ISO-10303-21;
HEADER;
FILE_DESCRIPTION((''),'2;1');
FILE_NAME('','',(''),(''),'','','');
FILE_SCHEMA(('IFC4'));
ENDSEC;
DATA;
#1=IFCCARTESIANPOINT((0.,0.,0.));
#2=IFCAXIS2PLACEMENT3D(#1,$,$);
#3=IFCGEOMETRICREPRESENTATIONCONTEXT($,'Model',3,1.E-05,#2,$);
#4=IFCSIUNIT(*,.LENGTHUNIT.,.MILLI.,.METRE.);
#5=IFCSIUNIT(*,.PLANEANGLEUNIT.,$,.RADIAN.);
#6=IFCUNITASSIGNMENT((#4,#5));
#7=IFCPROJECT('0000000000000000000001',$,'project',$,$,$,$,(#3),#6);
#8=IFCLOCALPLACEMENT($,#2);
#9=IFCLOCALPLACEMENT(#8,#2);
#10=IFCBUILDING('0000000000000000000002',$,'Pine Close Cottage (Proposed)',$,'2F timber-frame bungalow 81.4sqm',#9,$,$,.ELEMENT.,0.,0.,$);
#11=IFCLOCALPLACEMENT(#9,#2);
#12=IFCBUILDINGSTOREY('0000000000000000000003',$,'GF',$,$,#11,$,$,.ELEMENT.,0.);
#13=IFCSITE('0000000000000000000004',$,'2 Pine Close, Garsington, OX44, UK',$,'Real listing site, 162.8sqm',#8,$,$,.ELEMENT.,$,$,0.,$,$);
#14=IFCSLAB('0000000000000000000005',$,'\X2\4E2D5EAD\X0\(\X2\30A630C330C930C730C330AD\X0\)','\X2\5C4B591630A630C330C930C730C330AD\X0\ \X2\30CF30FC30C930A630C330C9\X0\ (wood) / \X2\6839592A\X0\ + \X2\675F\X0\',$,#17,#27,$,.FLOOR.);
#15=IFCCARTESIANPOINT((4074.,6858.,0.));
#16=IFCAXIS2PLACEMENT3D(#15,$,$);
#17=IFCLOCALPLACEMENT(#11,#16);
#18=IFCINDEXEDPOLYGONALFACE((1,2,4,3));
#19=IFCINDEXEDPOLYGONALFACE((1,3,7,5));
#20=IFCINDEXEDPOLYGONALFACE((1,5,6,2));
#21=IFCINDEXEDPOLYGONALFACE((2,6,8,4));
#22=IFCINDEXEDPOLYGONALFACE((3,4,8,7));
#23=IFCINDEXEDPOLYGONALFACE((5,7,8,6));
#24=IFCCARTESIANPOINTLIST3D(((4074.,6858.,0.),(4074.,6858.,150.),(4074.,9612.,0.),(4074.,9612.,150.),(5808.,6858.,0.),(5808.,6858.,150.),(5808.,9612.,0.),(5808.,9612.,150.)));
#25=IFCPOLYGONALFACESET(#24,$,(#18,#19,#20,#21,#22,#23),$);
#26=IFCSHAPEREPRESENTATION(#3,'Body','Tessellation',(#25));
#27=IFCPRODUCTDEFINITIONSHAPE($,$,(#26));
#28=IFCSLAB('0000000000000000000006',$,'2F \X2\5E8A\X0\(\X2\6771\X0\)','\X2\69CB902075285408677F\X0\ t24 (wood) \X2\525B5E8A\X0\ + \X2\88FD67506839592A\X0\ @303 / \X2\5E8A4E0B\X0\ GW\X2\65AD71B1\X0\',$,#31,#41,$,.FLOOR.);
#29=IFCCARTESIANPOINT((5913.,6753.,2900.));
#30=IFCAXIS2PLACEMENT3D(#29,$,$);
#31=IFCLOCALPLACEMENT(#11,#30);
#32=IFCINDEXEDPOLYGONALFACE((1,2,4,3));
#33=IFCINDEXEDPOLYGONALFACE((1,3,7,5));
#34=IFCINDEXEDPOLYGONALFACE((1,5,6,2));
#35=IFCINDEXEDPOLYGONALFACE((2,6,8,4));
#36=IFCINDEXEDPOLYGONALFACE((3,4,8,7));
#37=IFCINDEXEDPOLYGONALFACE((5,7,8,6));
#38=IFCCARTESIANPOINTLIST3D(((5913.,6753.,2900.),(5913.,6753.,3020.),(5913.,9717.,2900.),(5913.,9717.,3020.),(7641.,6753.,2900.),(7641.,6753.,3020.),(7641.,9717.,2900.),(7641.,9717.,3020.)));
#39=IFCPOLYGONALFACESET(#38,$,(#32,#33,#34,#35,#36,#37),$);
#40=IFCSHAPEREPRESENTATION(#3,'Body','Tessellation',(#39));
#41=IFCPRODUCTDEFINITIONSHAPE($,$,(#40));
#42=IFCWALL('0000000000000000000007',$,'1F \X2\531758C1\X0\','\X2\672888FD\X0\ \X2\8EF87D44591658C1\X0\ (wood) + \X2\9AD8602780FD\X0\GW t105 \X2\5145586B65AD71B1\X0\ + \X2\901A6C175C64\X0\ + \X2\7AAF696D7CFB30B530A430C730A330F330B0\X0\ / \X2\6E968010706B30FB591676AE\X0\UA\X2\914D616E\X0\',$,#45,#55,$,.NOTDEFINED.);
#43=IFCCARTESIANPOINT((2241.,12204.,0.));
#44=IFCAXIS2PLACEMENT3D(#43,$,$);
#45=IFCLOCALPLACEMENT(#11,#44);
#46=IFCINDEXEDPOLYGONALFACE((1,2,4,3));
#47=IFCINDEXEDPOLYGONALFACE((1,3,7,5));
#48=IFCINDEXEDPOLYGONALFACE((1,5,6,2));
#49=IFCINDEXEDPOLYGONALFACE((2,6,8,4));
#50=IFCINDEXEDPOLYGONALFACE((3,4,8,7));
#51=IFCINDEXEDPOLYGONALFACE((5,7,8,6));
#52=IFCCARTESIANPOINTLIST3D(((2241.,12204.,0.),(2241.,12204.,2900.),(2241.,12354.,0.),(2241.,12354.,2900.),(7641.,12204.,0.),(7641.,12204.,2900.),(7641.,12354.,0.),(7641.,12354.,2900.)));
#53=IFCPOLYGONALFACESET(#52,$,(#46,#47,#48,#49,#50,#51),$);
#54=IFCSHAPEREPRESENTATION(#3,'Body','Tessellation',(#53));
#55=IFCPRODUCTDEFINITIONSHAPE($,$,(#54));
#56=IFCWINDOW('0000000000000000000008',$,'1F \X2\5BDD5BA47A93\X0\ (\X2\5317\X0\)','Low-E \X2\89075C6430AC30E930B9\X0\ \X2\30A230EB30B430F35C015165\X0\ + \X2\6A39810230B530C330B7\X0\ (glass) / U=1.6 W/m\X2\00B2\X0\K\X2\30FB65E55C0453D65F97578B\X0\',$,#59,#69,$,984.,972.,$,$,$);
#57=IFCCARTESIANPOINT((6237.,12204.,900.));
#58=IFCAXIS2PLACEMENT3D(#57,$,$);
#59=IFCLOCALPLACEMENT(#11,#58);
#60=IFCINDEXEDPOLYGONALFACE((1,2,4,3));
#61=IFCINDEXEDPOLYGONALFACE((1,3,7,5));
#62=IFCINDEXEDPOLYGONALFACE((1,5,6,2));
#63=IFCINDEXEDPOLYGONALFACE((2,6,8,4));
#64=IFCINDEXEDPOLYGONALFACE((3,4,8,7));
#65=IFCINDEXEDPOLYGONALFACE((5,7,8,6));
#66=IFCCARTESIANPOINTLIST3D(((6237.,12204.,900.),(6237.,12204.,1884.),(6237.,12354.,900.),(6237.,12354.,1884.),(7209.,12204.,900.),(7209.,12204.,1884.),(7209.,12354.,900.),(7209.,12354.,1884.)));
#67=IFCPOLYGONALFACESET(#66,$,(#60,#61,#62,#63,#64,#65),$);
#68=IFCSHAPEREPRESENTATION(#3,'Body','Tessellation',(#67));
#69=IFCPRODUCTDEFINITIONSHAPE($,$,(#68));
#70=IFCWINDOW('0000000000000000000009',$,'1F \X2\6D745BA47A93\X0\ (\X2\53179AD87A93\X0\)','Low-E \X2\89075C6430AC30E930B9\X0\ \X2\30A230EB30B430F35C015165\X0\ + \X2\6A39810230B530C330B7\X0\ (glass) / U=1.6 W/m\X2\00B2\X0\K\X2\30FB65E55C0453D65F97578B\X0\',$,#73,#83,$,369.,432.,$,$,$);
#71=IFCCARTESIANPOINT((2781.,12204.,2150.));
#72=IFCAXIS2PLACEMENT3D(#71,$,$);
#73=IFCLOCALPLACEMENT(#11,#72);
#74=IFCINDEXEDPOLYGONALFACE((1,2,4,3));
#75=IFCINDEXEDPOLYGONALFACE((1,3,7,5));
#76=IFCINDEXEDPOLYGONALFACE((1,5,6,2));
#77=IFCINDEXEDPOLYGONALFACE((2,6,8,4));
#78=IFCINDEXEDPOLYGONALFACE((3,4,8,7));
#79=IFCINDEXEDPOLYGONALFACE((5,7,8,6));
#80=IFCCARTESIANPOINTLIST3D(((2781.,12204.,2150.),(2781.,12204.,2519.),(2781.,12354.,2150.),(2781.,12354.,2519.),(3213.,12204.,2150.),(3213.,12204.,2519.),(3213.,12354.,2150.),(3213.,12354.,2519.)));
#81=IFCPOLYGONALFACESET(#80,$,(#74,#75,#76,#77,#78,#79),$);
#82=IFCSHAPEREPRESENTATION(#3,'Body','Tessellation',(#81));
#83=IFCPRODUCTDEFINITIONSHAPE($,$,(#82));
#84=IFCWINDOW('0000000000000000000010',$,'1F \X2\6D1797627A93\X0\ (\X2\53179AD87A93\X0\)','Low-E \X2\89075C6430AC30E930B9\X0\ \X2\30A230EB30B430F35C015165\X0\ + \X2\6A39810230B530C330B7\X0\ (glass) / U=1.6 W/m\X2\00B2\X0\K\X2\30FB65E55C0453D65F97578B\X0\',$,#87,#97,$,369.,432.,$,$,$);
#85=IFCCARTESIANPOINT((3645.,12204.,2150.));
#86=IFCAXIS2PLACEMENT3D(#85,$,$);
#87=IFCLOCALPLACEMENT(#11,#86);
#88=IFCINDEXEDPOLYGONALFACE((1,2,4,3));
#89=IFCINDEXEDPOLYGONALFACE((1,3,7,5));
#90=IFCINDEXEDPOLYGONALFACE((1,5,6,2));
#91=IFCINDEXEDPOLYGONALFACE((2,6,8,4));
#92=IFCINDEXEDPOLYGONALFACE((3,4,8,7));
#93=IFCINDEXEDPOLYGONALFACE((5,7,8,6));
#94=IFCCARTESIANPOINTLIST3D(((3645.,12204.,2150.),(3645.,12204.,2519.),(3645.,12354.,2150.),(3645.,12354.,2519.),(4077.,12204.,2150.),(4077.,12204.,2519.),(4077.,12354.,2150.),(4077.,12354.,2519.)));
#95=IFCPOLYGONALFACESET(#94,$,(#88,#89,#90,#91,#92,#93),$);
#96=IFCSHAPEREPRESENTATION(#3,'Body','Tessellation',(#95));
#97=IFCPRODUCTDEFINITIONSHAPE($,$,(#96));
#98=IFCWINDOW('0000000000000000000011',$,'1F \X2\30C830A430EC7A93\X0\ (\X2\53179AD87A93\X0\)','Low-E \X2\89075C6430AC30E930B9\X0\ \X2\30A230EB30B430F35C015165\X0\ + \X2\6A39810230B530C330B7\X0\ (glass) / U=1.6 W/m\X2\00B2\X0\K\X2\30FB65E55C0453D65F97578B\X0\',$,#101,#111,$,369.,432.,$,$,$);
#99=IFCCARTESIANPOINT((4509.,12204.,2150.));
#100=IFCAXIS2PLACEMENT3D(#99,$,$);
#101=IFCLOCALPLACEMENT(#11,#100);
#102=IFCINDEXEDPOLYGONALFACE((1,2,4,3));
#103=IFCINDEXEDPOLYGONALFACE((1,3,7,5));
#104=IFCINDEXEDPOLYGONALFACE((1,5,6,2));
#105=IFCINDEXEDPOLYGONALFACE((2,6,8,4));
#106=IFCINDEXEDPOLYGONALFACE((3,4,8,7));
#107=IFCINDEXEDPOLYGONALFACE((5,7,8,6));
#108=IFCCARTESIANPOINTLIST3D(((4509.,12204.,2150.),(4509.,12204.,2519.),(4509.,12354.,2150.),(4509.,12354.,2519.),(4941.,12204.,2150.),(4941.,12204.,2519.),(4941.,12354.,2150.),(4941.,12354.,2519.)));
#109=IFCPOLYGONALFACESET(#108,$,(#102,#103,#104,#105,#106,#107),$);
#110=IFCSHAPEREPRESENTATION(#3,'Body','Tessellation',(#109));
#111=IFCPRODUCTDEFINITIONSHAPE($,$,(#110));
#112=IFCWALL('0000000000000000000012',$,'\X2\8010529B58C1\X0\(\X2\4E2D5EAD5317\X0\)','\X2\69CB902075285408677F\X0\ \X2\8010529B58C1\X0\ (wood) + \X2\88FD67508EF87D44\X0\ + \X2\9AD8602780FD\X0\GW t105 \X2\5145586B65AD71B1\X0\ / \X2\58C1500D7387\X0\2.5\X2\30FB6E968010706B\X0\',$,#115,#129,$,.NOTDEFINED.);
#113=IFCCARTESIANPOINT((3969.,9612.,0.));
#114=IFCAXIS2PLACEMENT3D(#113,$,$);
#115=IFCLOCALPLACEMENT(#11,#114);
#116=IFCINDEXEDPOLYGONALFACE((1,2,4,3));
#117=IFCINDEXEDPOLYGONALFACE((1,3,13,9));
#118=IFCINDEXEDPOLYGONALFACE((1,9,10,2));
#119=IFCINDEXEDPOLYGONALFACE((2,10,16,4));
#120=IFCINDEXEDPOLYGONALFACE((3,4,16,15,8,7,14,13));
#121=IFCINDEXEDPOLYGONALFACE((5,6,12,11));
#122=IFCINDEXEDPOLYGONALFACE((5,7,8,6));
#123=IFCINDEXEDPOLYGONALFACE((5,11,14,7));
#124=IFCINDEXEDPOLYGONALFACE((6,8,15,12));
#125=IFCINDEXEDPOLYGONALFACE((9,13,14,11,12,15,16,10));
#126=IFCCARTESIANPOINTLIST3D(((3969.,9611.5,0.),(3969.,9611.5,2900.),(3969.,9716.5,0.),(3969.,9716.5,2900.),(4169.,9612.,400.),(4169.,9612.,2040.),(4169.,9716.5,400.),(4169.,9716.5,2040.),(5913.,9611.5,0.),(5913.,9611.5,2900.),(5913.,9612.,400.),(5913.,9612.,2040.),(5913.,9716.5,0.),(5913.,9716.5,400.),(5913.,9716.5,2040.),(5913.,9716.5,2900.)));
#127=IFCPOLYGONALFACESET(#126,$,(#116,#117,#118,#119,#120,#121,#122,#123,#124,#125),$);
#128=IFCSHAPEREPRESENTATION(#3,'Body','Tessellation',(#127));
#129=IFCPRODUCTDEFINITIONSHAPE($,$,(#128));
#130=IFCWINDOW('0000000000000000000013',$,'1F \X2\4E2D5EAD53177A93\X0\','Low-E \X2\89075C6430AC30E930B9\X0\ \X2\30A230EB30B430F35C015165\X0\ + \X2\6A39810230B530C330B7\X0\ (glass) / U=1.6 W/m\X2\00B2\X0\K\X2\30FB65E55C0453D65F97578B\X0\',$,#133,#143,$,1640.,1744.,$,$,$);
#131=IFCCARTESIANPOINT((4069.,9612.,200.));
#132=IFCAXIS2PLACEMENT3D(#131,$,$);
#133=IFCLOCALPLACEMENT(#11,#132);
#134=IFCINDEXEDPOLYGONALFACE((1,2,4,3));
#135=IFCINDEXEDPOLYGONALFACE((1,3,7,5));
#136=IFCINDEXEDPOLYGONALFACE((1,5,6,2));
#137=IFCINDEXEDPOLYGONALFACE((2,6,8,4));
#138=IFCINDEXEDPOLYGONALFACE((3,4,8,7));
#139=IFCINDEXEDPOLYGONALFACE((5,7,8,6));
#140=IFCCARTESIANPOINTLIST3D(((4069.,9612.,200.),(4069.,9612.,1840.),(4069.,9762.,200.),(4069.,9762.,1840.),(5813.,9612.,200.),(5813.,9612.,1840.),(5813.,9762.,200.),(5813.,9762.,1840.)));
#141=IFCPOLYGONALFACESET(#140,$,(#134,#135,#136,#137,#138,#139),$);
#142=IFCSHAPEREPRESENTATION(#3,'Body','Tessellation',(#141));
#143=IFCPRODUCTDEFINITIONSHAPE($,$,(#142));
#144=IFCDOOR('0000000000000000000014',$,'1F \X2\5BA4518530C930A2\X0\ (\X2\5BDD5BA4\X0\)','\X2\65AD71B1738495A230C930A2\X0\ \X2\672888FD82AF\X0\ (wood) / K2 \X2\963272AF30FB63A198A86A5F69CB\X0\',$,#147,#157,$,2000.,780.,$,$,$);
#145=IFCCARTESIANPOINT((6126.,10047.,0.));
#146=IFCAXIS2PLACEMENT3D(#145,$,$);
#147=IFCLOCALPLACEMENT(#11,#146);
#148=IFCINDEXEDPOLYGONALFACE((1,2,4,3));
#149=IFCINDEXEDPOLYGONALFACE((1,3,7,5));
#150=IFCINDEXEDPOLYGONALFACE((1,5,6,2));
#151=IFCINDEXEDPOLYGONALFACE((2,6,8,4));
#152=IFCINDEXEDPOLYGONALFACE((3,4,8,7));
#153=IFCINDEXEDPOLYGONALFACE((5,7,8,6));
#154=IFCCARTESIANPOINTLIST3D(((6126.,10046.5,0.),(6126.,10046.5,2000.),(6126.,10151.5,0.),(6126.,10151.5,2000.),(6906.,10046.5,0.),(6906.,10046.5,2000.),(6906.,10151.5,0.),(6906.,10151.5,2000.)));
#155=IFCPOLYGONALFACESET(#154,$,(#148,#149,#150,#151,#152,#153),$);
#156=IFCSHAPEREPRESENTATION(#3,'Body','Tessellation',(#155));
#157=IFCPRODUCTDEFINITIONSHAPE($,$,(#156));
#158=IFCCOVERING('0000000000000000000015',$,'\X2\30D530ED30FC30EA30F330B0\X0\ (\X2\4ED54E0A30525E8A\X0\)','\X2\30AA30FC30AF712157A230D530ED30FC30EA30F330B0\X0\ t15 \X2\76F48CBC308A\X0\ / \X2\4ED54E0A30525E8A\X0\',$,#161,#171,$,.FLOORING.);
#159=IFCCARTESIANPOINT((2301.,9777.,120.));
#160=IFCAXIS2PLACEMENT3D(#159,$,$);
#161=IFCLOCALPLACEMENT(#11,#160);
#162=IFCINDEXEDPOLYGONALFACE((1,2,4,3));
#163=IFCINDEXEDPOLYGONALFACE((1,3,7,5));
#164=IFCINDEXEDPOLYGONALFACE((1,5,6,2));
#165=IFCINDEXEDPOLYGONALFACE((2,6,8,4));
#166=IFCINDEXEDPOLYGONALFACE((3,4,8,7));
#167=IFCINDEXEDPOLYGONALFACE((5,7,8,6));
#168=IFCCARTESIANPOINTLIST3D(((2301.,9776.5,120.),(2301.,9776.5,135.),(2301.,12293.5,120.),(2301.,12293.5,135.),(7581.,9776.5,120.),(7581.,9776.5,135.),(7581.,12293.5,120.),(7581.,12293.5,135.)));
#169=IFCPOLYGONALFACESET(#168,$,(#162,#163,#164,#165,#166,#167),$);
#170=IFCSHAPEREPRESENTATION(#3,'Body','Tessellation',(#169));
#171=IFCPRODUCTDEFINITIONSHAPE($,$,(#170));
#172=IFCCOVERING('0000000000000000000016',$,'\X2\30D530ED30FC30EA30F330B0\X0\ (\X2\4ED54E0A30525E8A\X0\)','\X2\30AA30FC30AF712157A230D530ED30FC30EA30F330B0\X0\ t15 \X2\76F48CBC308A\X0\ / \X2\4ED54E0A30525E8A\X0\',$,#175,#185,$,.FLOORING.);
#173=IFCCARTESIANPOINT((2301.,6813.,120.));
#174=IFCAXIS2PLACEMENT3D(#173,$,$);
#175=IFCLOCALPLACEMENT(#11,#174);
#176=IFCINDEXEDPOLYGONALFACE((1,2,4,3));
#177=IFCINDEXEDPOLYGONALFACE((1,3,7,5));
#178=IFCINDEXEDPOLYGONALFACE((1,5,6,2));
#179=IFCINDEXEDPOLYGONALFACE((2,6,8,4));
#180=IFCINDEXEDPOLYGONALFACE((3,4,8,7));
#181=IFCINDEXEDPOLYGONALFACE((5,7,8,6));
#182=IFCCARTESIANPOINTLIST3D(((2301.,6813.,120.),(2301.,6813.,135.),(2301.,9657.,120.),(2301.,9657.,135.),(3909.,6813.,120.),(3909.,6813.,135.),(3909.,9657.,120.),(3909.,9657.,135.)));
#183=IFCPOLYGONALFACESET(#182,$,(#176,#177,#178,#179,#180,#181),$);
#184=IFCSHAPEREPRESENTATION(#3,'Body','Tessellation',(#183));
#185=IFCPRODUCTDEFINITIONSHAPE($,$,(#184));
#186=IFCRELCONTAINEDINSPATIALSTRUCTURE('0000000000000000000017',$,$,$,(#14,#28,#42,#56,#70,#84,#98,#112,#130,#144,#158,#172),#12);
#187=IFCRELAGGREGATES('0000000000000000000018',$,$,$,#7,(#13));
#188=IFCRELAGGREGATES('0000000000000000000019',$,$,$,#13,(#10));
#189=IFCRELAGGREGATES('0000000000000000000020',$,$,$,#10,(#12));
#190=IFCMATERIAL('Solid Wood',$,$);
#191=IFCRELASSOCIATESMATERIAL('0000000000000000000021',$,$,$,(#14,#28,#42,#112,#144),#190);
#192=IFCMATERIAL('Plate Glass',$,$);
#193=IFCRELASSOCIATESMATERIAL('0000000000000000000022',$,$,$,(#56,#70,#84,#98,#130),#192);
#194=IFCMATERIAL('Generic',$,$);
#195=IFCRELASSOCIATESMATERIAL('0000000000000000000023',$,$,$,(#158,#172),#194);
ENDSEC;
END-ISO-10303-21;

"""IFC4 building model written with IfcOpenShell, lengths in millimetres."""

from ifc_helpers import new_model, si_unit, frame, frame_2d, origin, place, context, project, spatial, rectangle, extrude, material, element, fill, save


model = new_model("IFC4")

# Units and contexts
model_context = context("Model", 3, precision=1e-05, world=origin())
ifc_project = project(units=[si_unit("LENGTHUNIT", "METRE", prefix="MILLI"), si_unit("PLANEANGLEUNIT", "RADIAN")], contexts=[model_context])

# Site, building, storey
site_placement = place(None, origin())
site = spatial("IfcSite", under=ifc_project, at=site_placement, Name="2 Pine Close, Garsington, OX44, UK", ObjectType="Real listing site, 162.8sqm", CompositionType="ELEMENT", RefElevation=0.0)
building_placement = place(site_placement, origin())
building = spatial("IfcBuilding", under=site, at=building_placement, Name="Pine Close Cottage (Proposed)", ObjectType="2F timber-frame bungalow 81.4sqm", CompositionType="ELEMENT", ElevationOfRefHeight=0.0, ElevationOfTerrain=0.0)
storey_placement = place(building_placement, origin())
storey = spatial("IfcBuildingStorey", under=building, at=storey_placement, Name="GF", CompositionType="ELEMENT", Elevation=0.0)

# Slabs
ifc_material_1 = material(Name="Solid Wood")
slab_1_placement = place(storey_placement, frame((4074.0, 6858.0, 0.0)))
element("IfcSlab", 1, at=slab_1_placement, inside=storey, material=ifc_material_1, Name="中庭(ウッドデッキ)", Description="屋外ウッドデッキ ハードウッド (wood) / 根太 + 束", PredefinedType="FLOOR", context=model_context, shape_type="SweptSolid", body=[
    extrude(rectangle(XDim=1734.0, YDim=2754.0, at=frame_2d((867.0, 1377.0))), frame((4074.0, 6858.0, 0.0)), (0.0, 0.0, 1.0), 150.0),
])
slab_2_placement = place(storey_placement, frame((5913.0, 6753.0, 2900.0)))
element("IfcSlab", 2, at=slab_2_placement, inside=storey, material=ifc_material_1, Name="2F 床(東)", Description="構造用合板 t24 (wood) 剛床 + 製材根太 @303 / 床下 GW断熱", PredefinedType="FLOOR", context=model_context, shape_type="SweptSolid", body=[
    extrude(rectangle(XDim=1728.0, YDim=2964.0, at=frame_2d((864.0, 1482.0))), frame((5913.0, 6753.0, 2900.0)), (0.0, 0.0, 1.0), 120.0),
])

# Wall, openings, windows
wall_1_placement = place(storey_placement, frame((2241.0, 12204.0, 0.0)))
wall_1 = element("IfcWall", 3, at=wall_1_placement, inside=storey, material=ifc_material_1, Name="1F 北壁", Description="木製 軸組外壁 (wood) + 高性能GW t105 充填断熱 + 通気層 + 窯業系サイディング / 準耐火・外皮UA配慮", PredefinedType="NOTDEFINED", context=model_context, shape_type="SweptSolid", body=[
    extrude(rectangle(XDim=5400.0, YDim=150.0, at=frame_2d((2700.0, 75.0))), frame((2241.0, 12204.0, 0.0)), (0.0, 0.0, 1.0), 2900.0),
])
opening_1_placement = place(storey_placement, frame((6237.0, 12204.0, 900.0)))
opening_1 = element("IfcOpeningElement", 4, at=opening_1_placement, cuts=wall_1, PredefinedType="NOTDEFINED", context=model_context, shape_type="SweptSolid", body=[
    extrude(rectangle(XDim=972.0, YDim=150.0, at=frame_2d((486.0, 75.0))), frame((6237.0, 12204.0, 900.0)), (0.0, 0.0, 1.0), 984.0),
])
opening_2_placement = place(storey_placement, frame((2781.0, 12204.0, 2150.0)))
opening_2 = element("IfcOpeningElement", 5, at=opening_2_placement, cuts=wall_1, PredefinedType="NOTDEFINED", context=model_context, shape_type="SweptSolid", body=[
    extrude(rectangle(XDim=432.0, YDim=150.0, at=frame_2d((216.0, 75.0))), frame((2781.0, 12204.0, 2150.0)), (0.0, 0.0, 1.0), 369.0),
])
opening_3_placement = place(storey_placement, frame((3645.0, 12204.0, 2150.0)))
opening_3 = element("IfcOpeningElement", 6, at=opening_3_placement, cuts=wall_1, PredefinedType="NOTDEFINED", context=model_context, shape_type="SweptSolid", body=[
    extrude(rectangle(XDim=432.0, YDim=150.0, at=frame_2d((216.0, 75.0))), frame((3645.0, 12204.0, 2150.0)), (0.0, 0.0, 1.0), 369.0),
])
opening_4_placement = place(storey_placement, frame((4509.0, 12204.0, 2150.0)))
opening_4 = element("IfcOpeningElement", 7, at=opening_4_placement, cuts=wall_1, PredefinedType="NOTDEFINED", context=model_context, shape_type="SweptSolid", body=[
    extrude(rectangle(XDim=432.0, YDim=150.0, at=frame_2d((216.0, 75.0))), frame((4509.0, 12204.0, 2150.0)), (0.0, 0.0, 1.0), 369.0),
])
ifc_material_2 = material(Name="Plate Glass")
window_1_placement = place(storey_placement, frame((6237.0, 12204.0, 900.0)))
window_1 = element("IfcWindow", 8, at=window_1_placement, inside=storey, material=ifc_material_2, Name="1F 寝室窓 (北)", Description="Low-E 複層ガラス アルゴン封入 + 樹脂サッシ (glass) / U=1.6 W/m²K・日射取得型", OverallHeight=984.0, OverallWidth=972.0, context=model_context, shape_type="SweptSolid", body=[
    extrude(rectangle(XDim=972.0, YDim=150.0, at=frame_2d((486.0, 75.0))), frame((6237.0, 12204.0, 900.0)), (0.0, 0.0, 1.0), 984.0),
])
fill(opening_1, window_1)
window_2_placement = place(storey_placement, frame((2781.0, 12204.0, 2150.0)))
window_2 = element("IfcWindow", 9, at=window_2_placement, inside=storey, material=ifc_material_2, Name="1F 浴室窓 (北高窓)", Description="Low-E 複層ガラス アルゴン封入 + 樹脂サッシ (glass) / U=1.6 W/m²K・日射取得型", OverallHeight=369.0, OverallWidth=432.0, context=model_context, shape_type="SweptSolid", body=[
    extrude(rectangle(XDim=432.0, YDim=150.0, at=frame_2d((216.0, 75.0))), frame((2781.0, 12204.0, 2150.0)), (0.0, 0.0, 1.0), 369.0),
])
fill(opening_2, window_2)
window_3_placement = place(storey_placement, frame((3645.0, 12204.0, 2150.0)))
window_3 = element("IfcWindow", 10, at=window_3_placement, inside=storey, material=ifc_material_2, Name="1F 洗面窓 (北高窓)", Description="Low-E 複層ガラス アルゴン封入 + 樹脂サッシ (glass) / U=1.6 W/m²K・日射取得型", OverallHeight=369.0, OverallWidth=432.0, context=model_context, shape_type="SweptSolid", body=[
    extrude(rectangle(XDim=432.0, YDim=150.0, at=frame_2d((216.0, 75.0))), frame((3645.0, 12204.0, 2150.0)), (0.0, 0.0, 1.0), 369.0),
])
fill(opening_3, window_3)
window_4_placement = place(storey_placement, frame((4509.0, 12204.0, 2150.0)))
window_4 = element("IfcWindow", 11, at=window_4_placement, inside=storey, material=ifc_material_2, Name="1F トイレ窓 (北高窓)", Description="Low-E 複層ガラス アルゴン封入 + 樹脂サッシ (glass) / U=1.6 W/m²K・日射取得型", OverallHeight=369.0, OverallWidth=432.0, context=model_context, shape_type="SweptSolid", body=[
    extrude(rectangle(XDim=432.0, YDim=150.0, at=frame_2d((216.0, 75.0))), frame((4509.0, 12204.0, 2150.0)), (0.0, 0.0, 1.0), 369.0),
])
fill(opening_4, window_4)

# Wall, opening, window
wall_2_placement = place(storey_placement, frame((3969.0, 9612.0, 0.0)))
wall_2 = element("IfcWall", 12, at=wall_2_placement, inside=storey, material=ifc_material_1, Name="耐力壁(中庭北)", Description="構造用合板 耐力壁 (wood) + 製材軸組 + 高性能GW t105 充填断熱 / 壁倍率2.5・準耐火", PredefinedType="NOTDEFINED", context=model_context, shape_type="SweptSolid", body=[
    extrude(rectangle(XDim=1944.0, YDim=105.0, at=frame_2d((972.0, 52.0))), frame((3969.0, 9612.0, 0.0)), (0.0, 0.0, 1.0), 2900.0),
])
opening_5_placement = place(storey_placement, frame((4069.0, 9612.0, 200.0)))
opening_5 = element("IfcOpeningElement", 13, at=opening_5_placement, cuts=wall_2, PredefinedType="NOTDEFINED", context=model_context, shape_type="SweptSolid", body=[
    extrude(rectangle(XDim=1744.0, YDim=150.0, at=frame_2d((872.0, 75.0))), frame((4069.0, 9612.0, 200.0)), (0.0, 0.0, 1.0), 1640.0),
])
window_5_placement = place(storey_placement, frame((4069.0, 9612.0, 200.0)))
window_5 = element("IfcWindow", 14, at=window_5_placement, inside=storey, material=ifc_material_2, Name="1F 中庭北窓", Description="Low-E 複層ガラス アルゴン封入 + 樹脂サッシ (glass) / U=1.6 W/m²K・日射取得型", OverallHeight=1640.0, OverallWidth=1744.0, context=model_context, shape_type="SweptSolid", body=[
    extrude(rectangle(XDim=1744.0, YDim=150.0, at=frame_2d((872.0, 75.0))), frame((4069.0, 9612.0, 200.0)), (0.0, 0.0, 1.0), 1640.0),
])
fill(opening_5, window_5)

# Door
door_1_placement = place(storey_placement, frame((6126.0, 10047.0, 0.0)))
element("IfcDoor", 15, at=door_1_placement, inside=storey, material=ifc_material_1, Name="1F 室内ドア (寝室)", Description="断熱玄関ドア 木製芯 (wood) / K2 防犯・採風機構", OverallHeight=2000.0, OverallWidth=780.0, context=model_context, shape_type="SweptSolid", body=[
    extrude(rectangle(XDim=780.0, YDim=105.0, at=frame_2d((390.0, 52.0))), frame((6126.0, 10047.0, 0.0)), (0.0, 0.0, 1.0), 2000.0),
])

# Coverings
ifc_material_3 = material(Name="Generic")
covering_1_placement = place(storey_placement, frame((2301.0, 9777.0, 120.0)))
element("IfcCovering", 16, at=covering_1_placement, inside=storey, material=ifc_material_3, Name="フローリング (仕上げ床)", Description="オーク無垢フローリング t15 直貼り / 仕上げ床", PredefinedType="FLOORING", context=model_context, shape_type="SweptSolid", body=[
    extrude(rectangle(XDim=5280.0, YDim=2517.0, at=frame_2d((2640.0, 1258.0))), frame((2301.0, 9777.0, 120.0)), (0.0, 0.0, 1.0), 15.0),
])
covering_2_placement = place(storey_placement, frame((2301.0, 6813.0, 120.0)))
element("IfcCovering", 17, at=covering_2_placement, inside=storey, material=ifc_material_3, Name="フローリング (仕上げ床)", Description="オーク無垢フローリング t15 直貼り / 仕上げ床", PredefinedType="FLOORING", context=model_context, shape_type="SweptSolid", body=[
    extrude(rectangle(XDim=1608.0, YDim=2844.0, at=frame_2d((804.0, 1422.0))), frame((2301.0, 6813.0, 120.0)), (0.0, 0.0, 1.0), 15.0),
])

save(model, "model.ifc")
